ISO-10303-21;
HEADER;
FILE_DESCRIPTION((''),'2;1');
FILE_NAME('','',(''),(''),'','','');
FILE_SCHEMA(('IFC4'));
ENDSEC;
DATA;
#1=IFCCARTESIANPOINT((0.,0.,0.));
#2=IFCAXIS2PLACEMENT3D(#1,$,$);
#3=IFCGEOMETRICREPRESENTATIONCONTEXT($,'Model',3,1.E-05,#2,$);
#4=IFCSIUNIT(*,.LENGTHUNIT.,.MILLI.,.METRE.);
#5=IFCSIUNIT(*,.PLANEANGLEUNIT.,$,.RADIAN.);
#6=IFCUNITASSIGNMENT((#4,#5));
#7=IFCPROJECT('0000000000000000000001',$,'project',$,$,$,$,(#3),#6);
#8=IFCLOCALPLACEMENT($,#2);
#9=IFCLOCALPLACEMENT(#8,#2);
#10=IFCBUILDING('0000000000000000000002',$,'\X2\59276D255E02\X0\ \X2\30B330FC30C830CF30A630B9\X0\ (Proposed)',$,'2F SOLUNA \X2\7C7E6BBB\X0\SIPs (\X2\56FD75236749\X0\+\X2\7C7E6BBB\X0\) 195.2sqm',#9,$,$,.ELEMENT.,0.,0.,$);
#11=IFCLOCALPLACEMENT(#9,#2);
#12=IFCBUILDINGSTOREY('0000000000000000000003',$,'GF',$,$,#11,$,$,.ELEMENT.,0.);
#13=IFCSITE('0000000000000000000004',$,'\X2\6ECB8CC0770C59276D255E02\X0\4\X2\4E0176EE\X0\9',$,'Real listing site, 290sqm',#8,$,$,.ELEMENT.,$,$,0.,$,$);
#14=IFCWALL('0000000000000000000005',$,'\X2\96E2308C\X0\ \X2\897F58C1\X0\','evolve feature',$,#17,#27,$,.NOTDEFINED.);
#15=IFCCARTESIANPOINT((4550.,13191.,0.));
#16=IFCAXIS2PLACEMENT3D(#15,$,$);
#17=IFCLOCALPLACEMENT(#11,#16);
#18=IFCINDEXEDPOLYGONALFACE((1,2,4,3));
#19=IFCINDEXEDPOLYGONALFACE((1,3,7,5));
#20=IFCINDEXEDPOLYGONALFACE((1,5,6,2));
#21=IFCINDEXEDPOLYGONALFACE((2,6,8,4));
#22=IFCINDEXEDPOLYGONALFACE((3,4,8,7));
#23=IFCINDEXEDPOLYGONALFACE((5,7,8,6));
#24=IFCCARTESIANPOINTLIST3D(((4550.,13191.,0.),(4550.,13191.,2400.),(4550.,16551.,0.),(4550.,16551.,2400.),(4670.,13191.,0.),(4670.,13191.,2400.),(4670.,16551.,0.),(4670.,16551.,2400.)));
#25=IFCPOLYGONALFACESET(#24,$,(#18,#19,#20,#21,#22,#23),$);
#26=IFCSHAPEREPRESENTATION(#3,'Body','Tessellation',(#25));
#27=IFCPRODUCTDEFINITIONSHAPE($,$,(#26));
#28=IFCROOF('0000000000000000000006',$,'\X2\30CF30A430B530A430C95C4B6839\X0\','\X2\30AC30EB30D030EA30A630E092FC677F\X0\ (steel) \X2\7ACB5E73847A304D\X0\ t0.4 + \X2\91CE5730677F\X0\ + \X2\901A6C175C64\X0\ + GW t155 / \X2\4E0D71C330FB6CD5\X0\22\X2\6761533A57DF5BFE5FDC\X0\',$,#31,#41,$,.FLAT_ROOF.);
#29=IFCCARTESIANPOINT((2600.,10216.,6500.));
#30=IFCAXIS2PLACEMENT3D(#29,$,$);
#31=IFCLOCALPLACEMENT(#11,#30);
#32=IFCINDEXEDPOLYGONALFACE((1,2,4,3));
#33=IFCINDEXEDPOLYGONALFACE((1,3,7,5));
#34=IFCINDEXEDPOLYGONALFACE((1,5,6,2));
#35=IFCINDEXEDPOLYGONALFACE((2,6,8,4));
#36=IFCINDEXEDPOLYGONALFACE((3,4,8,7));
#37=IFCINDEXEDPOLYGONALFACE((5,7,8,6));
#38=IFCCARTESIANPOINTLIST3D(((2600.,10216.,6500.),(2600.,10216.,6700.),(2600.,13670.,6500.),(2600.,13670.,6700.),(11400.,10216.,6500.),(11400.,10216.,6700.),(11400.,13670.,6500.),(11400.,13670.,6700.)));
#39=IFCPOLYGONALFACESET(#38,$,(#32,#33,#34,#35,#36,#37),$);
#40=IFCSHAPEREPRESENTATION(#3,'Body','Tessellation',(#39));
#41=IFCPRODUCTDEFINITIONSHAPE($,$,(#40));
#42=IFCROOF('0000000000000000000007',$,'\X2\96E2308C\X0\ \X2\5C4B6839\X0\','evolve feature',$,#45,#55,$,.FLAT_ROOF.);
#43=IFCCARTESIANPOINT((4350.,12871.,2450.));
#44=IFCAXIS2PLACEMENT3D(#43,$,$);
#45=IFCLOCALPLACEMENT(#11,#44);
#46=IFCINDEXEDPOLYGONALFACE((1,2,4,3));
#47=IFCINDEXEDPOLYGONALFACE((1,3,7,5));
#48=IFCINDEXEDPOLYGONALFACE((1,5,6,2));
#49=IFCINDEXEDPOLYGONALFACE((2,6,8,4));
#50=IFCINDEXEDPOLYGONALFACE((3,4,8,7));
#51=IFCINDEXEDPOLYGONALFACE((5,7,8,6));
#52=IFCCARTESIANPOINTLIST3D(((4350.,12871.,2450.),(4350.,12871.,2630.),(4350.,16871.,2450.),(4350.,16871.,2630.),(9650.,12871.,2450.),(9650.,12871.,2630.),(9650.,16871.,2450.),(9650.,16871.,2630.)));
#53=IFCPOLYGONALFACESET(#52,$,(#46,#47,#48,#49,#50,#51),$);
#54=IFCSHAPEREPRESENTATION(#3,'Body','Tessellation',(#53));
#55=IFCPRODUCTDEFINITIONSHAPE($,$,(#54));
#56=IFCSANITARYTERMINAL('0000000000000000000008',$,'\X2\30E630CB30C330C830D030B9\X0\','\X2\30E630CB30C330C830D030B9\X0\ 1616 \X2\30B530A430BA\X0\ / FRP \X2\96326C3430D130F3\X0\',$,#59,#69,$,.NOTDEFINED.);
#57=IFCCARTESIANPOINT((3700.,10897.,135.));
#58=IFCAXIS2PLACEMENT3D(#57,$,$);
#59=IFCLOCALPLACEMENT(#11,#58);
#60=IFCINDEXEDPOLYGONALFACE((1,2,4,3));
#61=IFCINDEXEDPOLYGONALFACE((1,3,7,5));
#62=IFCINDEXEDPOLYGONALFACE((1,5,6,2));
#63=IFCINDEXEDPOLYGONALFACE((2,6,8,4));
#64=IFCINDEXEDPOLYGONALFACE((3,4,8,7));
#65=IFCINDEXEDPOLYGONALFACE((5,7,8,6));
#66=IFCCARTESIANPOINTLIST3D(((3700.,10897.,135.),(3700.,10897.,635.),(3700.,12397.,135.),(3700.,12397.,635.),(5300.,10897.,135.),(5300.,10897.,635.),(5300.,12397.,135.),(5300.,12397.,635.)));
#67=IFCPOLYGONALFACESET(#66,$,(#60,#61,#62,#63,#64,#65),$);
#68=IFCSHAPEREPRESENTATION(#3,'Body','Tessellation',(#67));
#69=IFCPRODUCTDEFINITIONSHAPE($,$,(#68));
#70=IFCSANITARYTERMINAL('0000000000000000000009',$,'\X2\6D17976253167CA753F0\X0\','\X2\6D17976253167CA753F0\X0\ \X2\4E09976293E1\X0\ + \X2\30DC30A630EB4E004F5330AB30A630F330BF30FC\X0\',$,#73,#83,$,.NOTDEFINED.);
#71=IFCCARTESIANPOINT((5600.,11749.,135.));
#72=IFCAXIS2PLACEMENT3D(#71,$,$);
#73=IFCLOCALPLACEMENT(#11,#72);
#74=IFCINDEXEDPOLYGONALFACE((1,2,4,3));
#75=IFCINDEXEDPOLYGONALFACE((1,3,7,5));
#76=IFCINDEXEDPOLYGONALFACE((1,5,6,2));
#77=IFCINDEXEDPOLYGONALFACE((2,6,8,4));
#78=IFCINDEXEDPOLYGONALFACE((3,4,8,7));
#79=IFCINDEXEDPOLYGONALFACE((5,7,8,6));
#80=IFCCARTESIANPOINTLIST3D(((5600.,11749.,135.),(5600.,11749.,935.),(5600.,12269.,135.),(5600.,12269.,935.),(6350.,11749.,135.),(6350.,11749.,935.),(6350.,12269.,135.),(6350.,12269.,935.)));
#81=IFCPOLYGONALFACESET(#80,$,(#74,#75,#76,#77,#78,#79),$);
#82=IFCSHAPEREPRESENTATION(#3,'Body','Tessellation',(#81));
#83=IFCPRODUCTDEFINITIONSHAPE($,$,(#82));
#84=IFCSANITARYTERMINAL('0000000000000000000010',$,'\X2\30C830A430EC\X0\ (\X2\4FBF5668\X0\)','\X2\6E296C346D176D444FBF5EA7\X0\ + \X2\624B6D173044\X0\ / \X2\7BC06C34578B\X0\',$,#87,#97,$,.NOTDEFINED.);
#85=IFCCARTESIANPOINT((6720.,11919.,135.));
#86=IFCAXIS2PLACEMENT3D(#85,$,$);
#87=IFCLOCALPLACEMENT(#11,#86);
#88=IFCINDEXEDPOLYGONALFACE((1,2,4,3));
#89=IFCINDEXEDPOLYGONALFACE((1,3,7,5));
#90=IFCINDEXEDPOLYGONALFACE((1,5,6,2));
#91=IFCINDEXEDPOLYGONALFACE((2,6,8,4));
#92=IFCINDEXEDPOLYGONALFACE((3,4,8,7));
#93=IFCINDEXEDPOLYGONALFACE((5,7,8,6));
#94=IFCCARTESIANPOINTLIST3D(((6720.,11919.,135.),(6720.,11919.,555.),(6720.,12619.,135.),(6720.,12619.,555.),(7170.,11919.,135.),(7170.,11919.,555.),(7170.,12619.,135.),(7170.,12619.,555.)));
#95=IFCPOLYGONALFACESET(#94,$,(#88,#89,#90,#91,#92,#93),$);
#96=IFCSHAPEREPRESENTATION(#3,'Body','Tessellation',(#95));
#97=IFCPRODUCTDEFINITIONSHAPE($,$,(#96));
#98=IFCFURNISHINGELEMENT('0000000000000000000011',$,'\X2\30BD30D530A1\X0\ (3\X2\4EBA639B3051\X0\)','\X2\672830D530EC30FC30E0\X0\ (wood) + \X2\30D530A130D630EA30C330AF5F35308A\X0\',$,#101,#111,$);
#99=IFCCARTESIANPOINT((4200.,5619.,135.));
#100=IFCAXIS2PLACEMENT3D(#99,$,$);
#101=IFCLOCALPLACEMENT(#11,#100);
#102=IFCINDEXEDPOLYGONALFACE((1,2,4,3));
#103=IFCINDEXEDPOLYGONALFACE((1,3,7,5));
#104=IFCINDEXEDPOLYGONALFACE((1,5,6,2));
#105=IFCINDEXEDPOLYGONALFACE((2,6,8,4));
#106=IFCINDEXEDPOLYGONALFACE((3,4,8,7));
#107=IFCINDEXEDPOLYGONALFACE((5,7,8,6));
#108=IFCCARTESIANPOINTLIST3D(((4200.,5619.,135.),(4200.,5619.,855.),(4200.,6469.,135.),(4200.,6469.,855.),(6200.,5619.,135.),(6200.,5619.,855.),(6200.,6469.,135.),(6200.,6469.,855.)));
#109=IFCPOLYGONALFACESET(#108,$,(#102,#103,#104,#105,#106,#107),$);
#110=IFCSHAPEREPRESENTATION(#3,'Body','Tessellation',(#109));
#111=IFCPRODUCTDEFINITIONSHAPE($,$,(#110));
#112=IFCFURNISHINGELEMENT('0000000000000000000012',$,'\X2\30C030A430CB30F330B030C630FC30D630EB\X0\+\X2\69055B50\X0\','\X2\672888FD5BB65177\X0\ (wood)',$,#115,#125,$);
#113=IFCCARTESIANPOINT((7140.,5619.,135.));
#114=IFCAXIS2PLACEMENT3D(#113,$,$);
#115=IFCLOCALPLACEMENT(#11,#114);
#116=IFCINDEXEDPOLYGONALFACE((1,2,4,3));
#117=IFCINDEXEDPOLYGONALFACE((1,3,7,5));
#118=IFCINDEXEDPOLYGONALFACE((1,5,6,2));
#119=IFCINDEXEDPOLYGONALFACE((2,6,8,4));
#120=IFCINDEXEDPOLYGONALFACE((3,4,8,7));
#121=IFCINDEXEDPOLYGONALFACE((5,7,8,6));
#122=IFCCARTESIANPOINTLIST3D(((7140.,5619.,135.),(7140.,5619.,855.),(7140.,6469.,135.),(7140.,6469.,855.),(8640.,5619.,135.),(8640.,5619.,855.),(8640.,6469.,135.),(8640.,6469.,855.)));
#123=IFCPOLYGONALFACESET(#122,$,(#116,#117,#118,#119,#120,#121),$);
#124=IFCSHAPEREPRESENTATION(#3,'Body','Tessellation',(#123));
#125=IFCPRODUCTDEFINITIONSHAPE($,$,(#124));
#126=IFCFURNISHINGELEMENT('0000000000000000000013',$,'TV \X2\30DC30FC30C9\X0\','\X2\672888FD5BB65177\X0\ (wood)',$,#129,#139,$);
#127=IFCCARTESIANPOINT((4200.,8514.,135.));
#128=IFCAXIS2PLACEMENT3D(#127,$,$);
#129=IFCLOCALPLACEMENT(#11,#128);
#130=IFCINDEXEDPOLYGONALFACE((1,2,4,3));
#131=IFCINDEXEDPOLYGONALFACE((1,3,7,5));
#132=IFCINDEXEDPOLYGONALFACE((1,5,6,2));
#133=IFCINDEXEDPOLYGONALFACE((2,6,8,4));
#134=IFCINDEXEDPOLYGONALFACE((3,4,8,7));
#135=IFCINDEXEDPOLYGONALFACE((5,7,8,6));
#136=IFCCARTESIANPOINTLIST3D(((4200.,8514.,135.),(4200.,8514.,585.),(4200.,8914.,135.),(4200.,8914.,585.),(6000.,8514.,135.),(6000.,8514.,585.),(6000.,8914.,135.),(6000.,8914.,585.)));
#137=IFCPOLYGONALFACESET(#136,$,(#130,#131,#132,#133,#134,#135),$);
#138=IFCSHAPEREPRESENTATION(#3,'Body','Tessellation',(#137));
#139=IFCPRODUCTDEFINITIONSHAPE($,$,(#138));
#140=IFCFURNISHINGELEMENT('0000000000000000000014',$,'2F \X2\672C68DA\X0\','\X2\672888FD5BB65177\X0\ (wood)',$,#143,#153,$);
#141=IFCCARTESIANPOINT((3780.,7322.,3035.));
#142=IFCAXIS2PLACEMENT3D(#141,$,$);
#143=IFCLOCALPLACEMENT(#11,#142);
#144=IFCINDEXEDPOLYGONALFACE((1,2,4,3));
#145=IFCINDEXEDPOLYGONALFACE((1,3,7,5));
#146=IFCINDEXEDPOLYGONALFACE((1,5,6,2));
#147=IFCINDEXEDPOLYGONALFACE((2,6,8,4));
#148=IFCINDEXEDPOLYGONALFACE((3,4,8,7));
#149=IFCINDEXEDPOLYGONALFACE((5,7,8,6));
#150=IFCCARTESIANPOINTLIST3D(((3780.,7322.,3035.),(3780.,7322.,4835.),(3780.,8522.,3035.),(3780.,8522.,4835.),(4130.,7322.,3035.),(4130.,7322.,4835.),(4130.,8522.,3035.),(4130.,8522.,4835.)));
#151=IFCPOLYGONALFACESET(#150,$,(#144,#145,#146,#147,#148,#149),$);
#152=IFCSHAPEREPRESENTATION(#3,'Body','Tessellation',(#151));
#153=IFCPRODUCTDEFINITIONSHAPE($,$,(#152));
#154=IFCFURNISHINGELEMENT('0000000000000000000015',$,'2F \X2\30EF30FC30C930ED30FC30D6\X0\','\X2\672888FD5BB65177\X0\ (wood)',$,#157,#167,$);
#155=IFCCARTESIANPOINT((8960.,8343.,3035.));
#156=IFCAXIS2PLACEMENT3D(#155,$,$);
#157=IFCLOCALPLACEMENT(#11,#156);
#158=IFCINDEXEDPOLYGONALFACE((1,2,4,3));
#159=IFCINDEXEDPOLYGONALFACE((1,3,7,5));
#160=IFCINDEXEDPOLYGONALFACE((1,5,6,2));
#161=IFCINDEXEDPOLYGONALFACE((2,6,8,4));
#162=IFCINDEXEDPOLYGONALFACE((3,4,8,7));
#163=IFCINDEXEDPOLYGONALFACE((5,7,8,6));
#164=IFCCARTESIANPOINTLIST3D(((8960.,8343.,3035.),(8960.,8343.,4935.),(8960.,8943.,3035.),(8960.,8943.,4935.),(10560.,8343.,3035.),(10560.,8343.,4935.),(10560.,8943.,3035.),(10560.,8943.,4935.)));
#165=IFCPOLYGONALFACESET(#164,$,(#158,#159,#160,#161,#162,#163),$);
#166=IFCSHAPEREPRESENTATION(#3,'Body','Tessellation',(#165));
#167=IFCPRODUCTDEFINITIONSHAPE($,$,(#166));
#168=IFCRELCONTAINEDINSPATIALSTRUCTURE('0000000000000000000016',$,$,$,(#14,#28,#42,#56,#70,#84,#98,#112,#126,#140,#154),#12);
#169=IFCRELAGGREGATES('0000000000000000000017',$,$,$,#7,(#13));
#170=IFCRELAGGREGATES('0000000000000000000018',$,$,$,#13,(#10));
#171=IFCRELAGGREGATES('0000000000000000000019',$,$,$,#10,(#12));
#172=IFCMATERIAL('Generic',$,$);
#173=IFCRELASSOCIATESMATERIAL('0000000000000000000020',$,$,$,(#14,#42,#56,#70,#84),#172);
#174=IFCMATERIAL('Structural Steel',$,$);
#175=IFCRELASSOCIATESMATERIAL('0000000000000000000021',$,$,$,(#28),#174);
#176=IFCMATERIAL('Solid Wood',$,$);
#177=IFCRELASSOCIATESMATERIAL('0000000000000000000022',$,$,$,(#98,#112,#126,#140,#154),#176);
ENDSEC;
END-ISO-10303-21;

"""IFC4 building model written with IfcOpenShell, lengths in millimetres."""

from ifc_helpers import new_model, si_unit, frame, frame_2d, origin, place, context, project, spatial, rectangle, extrude, material, element, save


model = new_model("IFC4")

# Units and contexts
model_context = context("Model", 3, precision=1e-05, world=origin())
ifc_project = project(units=[si_unit("LENGTHUNIT", "METRE", prefix="MILLI"), si_unit("PLANEANGLEUNIT", "RADIAN")], contexts=[model_context])

# Site, building, storey
site_placement = place(None, origin())
site = spatial("IfcSite", under=ifc_project, at=site_placement, Name="滋賀県大津市4丁目9", ObjectType="Real listing site, 290sqm", CompositionType="ELEMENT", RefElevation=0.0)
building_placement = place(site_placement, origin())
building = spatial("IfcBuilding", under=site, at=building_placement, Name="大津市 コートハウス (Proposed)", ObjectType="2F SOLUNA 籾殻SIPs (国産杉+籾殻) 195.2sqm", CompositionType="ELEMENT", ElevationOfRefHeight=0.0, ElevationOfTerrain=0.0)
storey_placement = place(building_placement, origin())
storey = spatial("IfcBuildingStorey", under=building, at=storey_placement, Name="GF", CompositionType="ELEMENT", Elevation=0.0)

# Shared definitions
ifc_material_1 = material(Name="Generic")

# Shared definitions
ifc_material_2 = material(Name="Solid Wood")

# Wall
wall_1_placement = place(storey_placement, frame((4550.0, 13191.0, 0.0)))
element("IfcWall", 1, at=wall_1_placement, inside=storey, material=ifc_material_1, Name="離れ 西壁", Description="evolve feature", PredefinedType="NOTDEFINED", context=model_context, shape_type="SweptSolid", body=[
    extrude(rectangle(XDim=120.0, YDim=3360.0, at=frame_2d((60.0, 1680.0))), frame((4550.0, 13191.0, 0.0)), (0.0, 0.0, 1.0), 2400.0),
])

# Roofs
ifc_material_3 = material(Name="Structural Steel")
roof_1_placement = place(storey_placement, frame((2600.0, 10216.0, 6500.0)))
element("IfcRoof", 2, at=roof_1_placement, inside=storey, material=ifc_material_3, Name="ハイサイド屋根", Description="ガルバリウム鋼板 (steel) 立平葺き t0.4 + 野地板 + 通気層 + GW t155 / 不燃・法22条区域対応", PredefinedType="FLAT_ROOF", context=model_context, shape_type="SweptSolid", body=[
    extrude(rectangle(XDim=8800.0, YDim=3454.0, at=frame_2d((4400.0, 1727.0))), frame((2600.0, 10216.0, 6500.0)), (0.0, 0.0, 1.0), 200.0),
])
roof_2_placement = place(storey_placement, frame((4350.0, 12871.0, 2450.0)))
element("IfcRoof", 3, at=roof_2_placement, inside=storey, material=ifc_material_1, Name="離れ 屋根", Description="evolve feature", PredefinedType="FLAT_ROOF", context=model_context, shape_type="SweptSolid", body=[
    extrude(rectangle(XDim=5300.0, YDim=4000.0, at=frame_2d((2650.0, 2000.0))), frame((4350.0, 12871.0, 2450.0)), (0.0, 0.0, 1.0), 180.0),
])

# Sanitary terminals
sanitary_terminal_1_placement = place(storey_placement, frame((3700.0, 10897.0, 135.0)))
element("IfcSanitaryTerminal", 4, at=sanitary_terminal_1_placement, inside=storey, material=ifc_material_1, Name="ユニットバス", Description="ユニットバス 1616 サイズ / FRP 防水パン", PredefinedType="NOTDEFINED", context=model_context, shape_type="SweptSolid", body=[
    extrude(rectangle(XDim=1600.0, YDim=1500.0, at=frame_2d((800.0, 750.0))), frame((3700.0, 10897.0, 135.0)), (0.0, 0.0, 1.0), 500.0),
])
sanitary_terminal_2_placement = place(storey_placement, frame((5600.0, 11749.0, 135.0)))
element("IfcSanitaryTerminal", 5, at=sanitary_terminal_2_placement, inside=storey, material=ifc_material_1, Name="洗面化粧台", Description="洗面化粧台 三面鏡 + ボウル一体カウンター", PredefinedType="NOTDEFINED", context=model_context, shape_type="SweptSolid", body=[
    extrude(rectangle(XDim=750.0, YDim=520.0, at=frame_2d((375.0, 260.0))), frame((5600.0, 11749.0, 135.0)), (0.0, 0.0, 1.0), 800.0),
])
sanitary_terminal_3_placement = place(storey_placement, frame((6720.0, 11919.0, 135.0)))
element("IfcSanitaryTerminal", 6, at=sanitary_terminal_3_placement, inside=storey, material=ifc_material_1, Name="トイレ (便器)", Description="温水洗浄便座 + 手洗い / 節水型", PredefinedType="NOTDEFINED", context=model_context, shape_type="SweptSolid", body=[
    extrude(rectangle(XDim=450.0, YDim=700.0, at=frame_2d((225.0, 350.0))), frame((6720.0, 11919.0, 135.0)), (0.0, 0.0, 1.0), 420.0),
])

# Furnishing elements
furnishing_1_placement = place(storey_placement, frame((4200.0, 5619.0, 135.0)))
element("IfcFurnishingElement", 7, at=furnishing_1_placement, inside=storey, material=ifc_material_2, Name="ソファ (3人掛け)", Description="木フレーム (wood) + ファブリック張り", context=model_context, shape_type="SweptSolid", body=[
    extrude(rectangle(XDim=2000.0, YDim=850.0, at=frame_2d((1000.0, 425.0))), frame((4200.0, 5619.0, 135.0)), (0.0, 0.0, 1.0), 720.0),
])
furnishing_2_placement = place(storey_placement, frame((7140.0, 5619.0, 135.0)))
element("IfcFurnishingElement", 8, at=furnishing_2_placement, inside=storey, material=ifc_material_2, Name="ダイニングテーブル+椅子", Description="木製家具 (wood)", context=model_context, shape_type="SweptSolid", body=[
    extrude(rectangle(XDim=1500.0, YDim=850.0, at=frame_2d((750.0, 425.0))), frame((7140.0, 5619.0, 135.0)), (0.0, 0.0, 1.0), 720.0),
])
furnishing_3_placement = place(storey_placement, frame((4200.0, 8514.0, 135.0)))
element("IfcFurnishingElement", 9, at=furnishing_3_placement, inside=storey, material=ifc_material_2, Name="TV ボード", Description="木製家具 (wood)", context=model_context, shape_type="SweptSolid", body=[
    extrude(rectangle(XDim=1800.0, YDim=400.0, at=frame_2d((900.0, 200.0))), frame((4200.0, 8514.0, 135.0)), (0.0, 0.0, 1.0), 450.0),
])
furnishing_4_placement = place(storey_placement, frame((3780.0, 7322.0, 3035.0)))
element("IfcFurnishingElement", 10, at=furnishing_4_placement, inside=storey, material=ifc_material_2, Name="2F 本棚", Description="木製家具 (wood)", context=model_context, shape_type="SweptSolid", body=[
    extrude(rectangle(XDim=350.0, YDim=1200.0, at=frame_2d((175.0, 600.0))), frame((3780.0, 7322.0, 3035.0)), (0.0, 0.0, 1.0), 1800.0),
])
furnishing_5_placement = place(storey_placement, frame((8960.0, 8343.0, 3035.0)))
element("IfcFurnishingElement", 11, at=furnishing_5_placement, inside=storey, material=ifc_material_2, Name="2F ワードローブ", Description="木製家具 (wood)", context=model_context, shape_type="SweptSolid", body=[
    extrude(rectangle(XDim=1600.0, YDim=600.0, at=frame_2d((800.0, 300.0))), frame((8960.0, 8343.0, 3035.0)), (0.0, 0.0, 1.0), 1900.0),
])

save(model, "model.ifc")
